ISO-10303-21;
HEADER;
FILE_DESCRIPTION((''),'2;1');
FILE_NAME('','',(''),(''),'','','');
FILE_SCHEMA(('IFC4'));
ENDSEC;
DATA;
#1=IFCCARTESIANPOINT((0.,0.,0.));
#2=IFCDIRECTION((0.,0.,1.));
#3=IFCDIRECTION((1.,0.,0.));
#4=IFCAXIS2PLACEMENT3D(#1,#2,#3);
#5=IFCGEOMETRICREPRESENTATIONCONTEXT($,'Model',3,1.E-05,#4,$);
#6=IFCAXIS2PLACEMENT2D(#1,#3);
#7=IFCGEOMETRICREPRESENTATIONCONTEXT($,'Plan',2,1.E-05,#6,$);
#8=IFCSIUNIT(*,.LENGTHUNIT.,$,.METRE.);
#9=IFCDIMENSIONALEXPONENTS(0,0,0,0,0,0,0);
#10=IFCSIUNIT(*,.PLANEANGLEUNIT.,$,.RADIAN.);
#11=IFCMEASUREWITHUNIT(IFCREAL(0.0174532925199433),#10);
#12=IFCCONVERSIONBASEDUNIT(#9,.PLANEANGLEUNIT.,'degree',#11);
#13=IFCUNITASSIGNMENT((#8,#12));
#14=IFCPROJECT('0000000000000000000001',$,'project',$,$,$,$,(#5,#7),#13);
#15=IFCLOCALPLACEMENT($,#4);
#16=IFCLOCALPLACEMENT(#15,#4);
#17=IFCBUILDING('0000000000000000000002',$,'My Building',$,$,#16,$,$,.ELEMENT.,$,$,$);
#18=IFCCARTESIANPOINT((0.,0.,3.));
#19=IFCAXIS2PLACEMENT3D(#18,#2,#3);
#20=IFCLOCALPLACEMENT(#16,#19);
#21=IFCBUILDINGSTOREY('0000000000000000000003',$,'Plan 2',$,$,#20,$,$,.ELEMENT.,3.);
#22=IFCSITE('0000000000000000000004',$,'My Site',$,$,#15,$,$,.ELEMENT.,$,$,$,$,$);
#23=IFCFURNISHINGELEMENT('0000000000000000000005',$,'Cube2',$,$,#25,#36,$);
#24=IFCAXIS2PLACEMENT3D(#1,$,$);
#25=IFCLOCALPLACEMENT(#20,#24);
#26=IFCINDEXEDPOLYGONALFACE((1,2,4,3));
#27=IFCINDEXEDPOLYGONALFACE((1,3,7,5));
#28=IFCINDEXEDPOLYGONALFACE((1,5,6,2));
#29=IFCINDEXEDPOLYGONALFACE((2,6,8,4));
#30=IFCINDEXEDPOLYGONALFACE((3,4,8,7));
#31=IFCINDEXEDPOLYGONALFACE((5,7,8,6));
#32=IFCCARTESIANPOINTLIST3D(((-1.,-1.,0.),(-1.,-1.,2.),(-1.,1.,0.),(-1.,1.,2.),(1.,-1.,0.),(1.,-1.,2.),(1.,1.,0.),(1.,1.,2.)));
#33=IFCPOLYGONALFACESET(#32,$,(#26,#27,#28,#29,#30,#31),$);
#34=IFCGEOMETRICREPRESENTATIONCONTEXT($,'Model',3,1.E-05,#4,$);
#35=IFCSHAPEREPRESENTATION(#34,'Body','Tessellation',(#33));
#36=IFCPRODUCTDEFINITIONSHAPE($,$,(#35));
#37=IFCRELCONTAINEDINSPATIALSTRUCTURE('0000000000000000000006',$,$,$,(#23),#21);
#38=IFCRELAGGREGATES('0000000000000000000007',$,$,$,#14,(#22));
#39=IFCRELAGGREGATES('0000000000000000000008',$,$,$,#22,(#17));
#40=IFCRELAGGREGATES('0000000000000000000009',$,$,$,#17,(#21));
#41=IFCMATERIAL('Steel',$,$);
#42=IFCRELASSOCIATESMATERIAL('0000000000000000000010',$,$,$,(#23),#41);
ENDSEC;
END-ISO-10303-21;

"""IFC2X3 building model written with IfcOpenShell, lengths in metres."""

from ifc_helpers import new_model, entity, si_unit, converted_unit, frame, frame_2d, origin_with_axes, place, context, project, spatial, rectangle, extrude, shape, material, element, save


model = new_model("IFC2X3")

# Units and contexts
model_context_1 = context("Model", 3, precision=1e-05, world=origin_with_axes())
plan_context = context("Plan", 2, precision=1e-05, world=frame_2d((0.0, 0.0, 0.0), x_axis=(1.0, 0.0, 0.0)))
model_context_2 = context("Model", 3, precision=1e-05, world=origin_with_axes())
ifc_project = project(units=[si_unit("LENGTHUNIT", "METRE"), converted_unit("PLANEANGLEUNIT", "degree", entity("IfcReal", 0.0174532925199433), si_unit("PLANEANGLEUNIT", "RADIAN"), dimensions=[0, 0, 0, 0, 0, 0, 0])], contexts=[model_context_1, plan_context])

# Site, building, storey
site_placement = place(None, origin_with_axes())
site = spatial("IfcSite", under=ifc_project, at=site_placement, Name="My Site", CompositionType="ELEMENT")
building_placement = place(site_placement, origin_with_axes())
building = spatial("IfcBuilding", under=site, at=building_placement, Name="My Building", CompositionType="ELEMENT")
storey_placement = place(building_placement, frame((0.0, 0.0, 3.0), z_axis=(0.0, 0.0, 1.0), x_axis=(1.0, 0.0, 0.0)))
storey = spatial("IfcBuildingStorey", under=building, at=storey_placement, Name="Plan 2", CompositionType="ELEMENT", Elevation=3.0)

# Furnishing element
ifc_material = material(Name="Steel")
furnishing_placement = place(storey_placement, origin_with_axes())
element("IfcFurnishingElement", 1, at=furnishing_placement, inside=storey, material=ifc_material, Name="Cube2", shapes=[
    shape(model_context_2, None, "SweptSolid", [extrude(rectangle(XDim=2.0, YDim=2.0, at=frame_2d((0.0, 0.0, 0.0))), frame((0.0, 0.0, 0.0), z_axis=(0.0, 0.0, -1.0), x_axis=(1.0, 0.0, 0.0)), (0.0, 0.0, -1.0), 2.0)]),
])

save(model, "model.ifc")
